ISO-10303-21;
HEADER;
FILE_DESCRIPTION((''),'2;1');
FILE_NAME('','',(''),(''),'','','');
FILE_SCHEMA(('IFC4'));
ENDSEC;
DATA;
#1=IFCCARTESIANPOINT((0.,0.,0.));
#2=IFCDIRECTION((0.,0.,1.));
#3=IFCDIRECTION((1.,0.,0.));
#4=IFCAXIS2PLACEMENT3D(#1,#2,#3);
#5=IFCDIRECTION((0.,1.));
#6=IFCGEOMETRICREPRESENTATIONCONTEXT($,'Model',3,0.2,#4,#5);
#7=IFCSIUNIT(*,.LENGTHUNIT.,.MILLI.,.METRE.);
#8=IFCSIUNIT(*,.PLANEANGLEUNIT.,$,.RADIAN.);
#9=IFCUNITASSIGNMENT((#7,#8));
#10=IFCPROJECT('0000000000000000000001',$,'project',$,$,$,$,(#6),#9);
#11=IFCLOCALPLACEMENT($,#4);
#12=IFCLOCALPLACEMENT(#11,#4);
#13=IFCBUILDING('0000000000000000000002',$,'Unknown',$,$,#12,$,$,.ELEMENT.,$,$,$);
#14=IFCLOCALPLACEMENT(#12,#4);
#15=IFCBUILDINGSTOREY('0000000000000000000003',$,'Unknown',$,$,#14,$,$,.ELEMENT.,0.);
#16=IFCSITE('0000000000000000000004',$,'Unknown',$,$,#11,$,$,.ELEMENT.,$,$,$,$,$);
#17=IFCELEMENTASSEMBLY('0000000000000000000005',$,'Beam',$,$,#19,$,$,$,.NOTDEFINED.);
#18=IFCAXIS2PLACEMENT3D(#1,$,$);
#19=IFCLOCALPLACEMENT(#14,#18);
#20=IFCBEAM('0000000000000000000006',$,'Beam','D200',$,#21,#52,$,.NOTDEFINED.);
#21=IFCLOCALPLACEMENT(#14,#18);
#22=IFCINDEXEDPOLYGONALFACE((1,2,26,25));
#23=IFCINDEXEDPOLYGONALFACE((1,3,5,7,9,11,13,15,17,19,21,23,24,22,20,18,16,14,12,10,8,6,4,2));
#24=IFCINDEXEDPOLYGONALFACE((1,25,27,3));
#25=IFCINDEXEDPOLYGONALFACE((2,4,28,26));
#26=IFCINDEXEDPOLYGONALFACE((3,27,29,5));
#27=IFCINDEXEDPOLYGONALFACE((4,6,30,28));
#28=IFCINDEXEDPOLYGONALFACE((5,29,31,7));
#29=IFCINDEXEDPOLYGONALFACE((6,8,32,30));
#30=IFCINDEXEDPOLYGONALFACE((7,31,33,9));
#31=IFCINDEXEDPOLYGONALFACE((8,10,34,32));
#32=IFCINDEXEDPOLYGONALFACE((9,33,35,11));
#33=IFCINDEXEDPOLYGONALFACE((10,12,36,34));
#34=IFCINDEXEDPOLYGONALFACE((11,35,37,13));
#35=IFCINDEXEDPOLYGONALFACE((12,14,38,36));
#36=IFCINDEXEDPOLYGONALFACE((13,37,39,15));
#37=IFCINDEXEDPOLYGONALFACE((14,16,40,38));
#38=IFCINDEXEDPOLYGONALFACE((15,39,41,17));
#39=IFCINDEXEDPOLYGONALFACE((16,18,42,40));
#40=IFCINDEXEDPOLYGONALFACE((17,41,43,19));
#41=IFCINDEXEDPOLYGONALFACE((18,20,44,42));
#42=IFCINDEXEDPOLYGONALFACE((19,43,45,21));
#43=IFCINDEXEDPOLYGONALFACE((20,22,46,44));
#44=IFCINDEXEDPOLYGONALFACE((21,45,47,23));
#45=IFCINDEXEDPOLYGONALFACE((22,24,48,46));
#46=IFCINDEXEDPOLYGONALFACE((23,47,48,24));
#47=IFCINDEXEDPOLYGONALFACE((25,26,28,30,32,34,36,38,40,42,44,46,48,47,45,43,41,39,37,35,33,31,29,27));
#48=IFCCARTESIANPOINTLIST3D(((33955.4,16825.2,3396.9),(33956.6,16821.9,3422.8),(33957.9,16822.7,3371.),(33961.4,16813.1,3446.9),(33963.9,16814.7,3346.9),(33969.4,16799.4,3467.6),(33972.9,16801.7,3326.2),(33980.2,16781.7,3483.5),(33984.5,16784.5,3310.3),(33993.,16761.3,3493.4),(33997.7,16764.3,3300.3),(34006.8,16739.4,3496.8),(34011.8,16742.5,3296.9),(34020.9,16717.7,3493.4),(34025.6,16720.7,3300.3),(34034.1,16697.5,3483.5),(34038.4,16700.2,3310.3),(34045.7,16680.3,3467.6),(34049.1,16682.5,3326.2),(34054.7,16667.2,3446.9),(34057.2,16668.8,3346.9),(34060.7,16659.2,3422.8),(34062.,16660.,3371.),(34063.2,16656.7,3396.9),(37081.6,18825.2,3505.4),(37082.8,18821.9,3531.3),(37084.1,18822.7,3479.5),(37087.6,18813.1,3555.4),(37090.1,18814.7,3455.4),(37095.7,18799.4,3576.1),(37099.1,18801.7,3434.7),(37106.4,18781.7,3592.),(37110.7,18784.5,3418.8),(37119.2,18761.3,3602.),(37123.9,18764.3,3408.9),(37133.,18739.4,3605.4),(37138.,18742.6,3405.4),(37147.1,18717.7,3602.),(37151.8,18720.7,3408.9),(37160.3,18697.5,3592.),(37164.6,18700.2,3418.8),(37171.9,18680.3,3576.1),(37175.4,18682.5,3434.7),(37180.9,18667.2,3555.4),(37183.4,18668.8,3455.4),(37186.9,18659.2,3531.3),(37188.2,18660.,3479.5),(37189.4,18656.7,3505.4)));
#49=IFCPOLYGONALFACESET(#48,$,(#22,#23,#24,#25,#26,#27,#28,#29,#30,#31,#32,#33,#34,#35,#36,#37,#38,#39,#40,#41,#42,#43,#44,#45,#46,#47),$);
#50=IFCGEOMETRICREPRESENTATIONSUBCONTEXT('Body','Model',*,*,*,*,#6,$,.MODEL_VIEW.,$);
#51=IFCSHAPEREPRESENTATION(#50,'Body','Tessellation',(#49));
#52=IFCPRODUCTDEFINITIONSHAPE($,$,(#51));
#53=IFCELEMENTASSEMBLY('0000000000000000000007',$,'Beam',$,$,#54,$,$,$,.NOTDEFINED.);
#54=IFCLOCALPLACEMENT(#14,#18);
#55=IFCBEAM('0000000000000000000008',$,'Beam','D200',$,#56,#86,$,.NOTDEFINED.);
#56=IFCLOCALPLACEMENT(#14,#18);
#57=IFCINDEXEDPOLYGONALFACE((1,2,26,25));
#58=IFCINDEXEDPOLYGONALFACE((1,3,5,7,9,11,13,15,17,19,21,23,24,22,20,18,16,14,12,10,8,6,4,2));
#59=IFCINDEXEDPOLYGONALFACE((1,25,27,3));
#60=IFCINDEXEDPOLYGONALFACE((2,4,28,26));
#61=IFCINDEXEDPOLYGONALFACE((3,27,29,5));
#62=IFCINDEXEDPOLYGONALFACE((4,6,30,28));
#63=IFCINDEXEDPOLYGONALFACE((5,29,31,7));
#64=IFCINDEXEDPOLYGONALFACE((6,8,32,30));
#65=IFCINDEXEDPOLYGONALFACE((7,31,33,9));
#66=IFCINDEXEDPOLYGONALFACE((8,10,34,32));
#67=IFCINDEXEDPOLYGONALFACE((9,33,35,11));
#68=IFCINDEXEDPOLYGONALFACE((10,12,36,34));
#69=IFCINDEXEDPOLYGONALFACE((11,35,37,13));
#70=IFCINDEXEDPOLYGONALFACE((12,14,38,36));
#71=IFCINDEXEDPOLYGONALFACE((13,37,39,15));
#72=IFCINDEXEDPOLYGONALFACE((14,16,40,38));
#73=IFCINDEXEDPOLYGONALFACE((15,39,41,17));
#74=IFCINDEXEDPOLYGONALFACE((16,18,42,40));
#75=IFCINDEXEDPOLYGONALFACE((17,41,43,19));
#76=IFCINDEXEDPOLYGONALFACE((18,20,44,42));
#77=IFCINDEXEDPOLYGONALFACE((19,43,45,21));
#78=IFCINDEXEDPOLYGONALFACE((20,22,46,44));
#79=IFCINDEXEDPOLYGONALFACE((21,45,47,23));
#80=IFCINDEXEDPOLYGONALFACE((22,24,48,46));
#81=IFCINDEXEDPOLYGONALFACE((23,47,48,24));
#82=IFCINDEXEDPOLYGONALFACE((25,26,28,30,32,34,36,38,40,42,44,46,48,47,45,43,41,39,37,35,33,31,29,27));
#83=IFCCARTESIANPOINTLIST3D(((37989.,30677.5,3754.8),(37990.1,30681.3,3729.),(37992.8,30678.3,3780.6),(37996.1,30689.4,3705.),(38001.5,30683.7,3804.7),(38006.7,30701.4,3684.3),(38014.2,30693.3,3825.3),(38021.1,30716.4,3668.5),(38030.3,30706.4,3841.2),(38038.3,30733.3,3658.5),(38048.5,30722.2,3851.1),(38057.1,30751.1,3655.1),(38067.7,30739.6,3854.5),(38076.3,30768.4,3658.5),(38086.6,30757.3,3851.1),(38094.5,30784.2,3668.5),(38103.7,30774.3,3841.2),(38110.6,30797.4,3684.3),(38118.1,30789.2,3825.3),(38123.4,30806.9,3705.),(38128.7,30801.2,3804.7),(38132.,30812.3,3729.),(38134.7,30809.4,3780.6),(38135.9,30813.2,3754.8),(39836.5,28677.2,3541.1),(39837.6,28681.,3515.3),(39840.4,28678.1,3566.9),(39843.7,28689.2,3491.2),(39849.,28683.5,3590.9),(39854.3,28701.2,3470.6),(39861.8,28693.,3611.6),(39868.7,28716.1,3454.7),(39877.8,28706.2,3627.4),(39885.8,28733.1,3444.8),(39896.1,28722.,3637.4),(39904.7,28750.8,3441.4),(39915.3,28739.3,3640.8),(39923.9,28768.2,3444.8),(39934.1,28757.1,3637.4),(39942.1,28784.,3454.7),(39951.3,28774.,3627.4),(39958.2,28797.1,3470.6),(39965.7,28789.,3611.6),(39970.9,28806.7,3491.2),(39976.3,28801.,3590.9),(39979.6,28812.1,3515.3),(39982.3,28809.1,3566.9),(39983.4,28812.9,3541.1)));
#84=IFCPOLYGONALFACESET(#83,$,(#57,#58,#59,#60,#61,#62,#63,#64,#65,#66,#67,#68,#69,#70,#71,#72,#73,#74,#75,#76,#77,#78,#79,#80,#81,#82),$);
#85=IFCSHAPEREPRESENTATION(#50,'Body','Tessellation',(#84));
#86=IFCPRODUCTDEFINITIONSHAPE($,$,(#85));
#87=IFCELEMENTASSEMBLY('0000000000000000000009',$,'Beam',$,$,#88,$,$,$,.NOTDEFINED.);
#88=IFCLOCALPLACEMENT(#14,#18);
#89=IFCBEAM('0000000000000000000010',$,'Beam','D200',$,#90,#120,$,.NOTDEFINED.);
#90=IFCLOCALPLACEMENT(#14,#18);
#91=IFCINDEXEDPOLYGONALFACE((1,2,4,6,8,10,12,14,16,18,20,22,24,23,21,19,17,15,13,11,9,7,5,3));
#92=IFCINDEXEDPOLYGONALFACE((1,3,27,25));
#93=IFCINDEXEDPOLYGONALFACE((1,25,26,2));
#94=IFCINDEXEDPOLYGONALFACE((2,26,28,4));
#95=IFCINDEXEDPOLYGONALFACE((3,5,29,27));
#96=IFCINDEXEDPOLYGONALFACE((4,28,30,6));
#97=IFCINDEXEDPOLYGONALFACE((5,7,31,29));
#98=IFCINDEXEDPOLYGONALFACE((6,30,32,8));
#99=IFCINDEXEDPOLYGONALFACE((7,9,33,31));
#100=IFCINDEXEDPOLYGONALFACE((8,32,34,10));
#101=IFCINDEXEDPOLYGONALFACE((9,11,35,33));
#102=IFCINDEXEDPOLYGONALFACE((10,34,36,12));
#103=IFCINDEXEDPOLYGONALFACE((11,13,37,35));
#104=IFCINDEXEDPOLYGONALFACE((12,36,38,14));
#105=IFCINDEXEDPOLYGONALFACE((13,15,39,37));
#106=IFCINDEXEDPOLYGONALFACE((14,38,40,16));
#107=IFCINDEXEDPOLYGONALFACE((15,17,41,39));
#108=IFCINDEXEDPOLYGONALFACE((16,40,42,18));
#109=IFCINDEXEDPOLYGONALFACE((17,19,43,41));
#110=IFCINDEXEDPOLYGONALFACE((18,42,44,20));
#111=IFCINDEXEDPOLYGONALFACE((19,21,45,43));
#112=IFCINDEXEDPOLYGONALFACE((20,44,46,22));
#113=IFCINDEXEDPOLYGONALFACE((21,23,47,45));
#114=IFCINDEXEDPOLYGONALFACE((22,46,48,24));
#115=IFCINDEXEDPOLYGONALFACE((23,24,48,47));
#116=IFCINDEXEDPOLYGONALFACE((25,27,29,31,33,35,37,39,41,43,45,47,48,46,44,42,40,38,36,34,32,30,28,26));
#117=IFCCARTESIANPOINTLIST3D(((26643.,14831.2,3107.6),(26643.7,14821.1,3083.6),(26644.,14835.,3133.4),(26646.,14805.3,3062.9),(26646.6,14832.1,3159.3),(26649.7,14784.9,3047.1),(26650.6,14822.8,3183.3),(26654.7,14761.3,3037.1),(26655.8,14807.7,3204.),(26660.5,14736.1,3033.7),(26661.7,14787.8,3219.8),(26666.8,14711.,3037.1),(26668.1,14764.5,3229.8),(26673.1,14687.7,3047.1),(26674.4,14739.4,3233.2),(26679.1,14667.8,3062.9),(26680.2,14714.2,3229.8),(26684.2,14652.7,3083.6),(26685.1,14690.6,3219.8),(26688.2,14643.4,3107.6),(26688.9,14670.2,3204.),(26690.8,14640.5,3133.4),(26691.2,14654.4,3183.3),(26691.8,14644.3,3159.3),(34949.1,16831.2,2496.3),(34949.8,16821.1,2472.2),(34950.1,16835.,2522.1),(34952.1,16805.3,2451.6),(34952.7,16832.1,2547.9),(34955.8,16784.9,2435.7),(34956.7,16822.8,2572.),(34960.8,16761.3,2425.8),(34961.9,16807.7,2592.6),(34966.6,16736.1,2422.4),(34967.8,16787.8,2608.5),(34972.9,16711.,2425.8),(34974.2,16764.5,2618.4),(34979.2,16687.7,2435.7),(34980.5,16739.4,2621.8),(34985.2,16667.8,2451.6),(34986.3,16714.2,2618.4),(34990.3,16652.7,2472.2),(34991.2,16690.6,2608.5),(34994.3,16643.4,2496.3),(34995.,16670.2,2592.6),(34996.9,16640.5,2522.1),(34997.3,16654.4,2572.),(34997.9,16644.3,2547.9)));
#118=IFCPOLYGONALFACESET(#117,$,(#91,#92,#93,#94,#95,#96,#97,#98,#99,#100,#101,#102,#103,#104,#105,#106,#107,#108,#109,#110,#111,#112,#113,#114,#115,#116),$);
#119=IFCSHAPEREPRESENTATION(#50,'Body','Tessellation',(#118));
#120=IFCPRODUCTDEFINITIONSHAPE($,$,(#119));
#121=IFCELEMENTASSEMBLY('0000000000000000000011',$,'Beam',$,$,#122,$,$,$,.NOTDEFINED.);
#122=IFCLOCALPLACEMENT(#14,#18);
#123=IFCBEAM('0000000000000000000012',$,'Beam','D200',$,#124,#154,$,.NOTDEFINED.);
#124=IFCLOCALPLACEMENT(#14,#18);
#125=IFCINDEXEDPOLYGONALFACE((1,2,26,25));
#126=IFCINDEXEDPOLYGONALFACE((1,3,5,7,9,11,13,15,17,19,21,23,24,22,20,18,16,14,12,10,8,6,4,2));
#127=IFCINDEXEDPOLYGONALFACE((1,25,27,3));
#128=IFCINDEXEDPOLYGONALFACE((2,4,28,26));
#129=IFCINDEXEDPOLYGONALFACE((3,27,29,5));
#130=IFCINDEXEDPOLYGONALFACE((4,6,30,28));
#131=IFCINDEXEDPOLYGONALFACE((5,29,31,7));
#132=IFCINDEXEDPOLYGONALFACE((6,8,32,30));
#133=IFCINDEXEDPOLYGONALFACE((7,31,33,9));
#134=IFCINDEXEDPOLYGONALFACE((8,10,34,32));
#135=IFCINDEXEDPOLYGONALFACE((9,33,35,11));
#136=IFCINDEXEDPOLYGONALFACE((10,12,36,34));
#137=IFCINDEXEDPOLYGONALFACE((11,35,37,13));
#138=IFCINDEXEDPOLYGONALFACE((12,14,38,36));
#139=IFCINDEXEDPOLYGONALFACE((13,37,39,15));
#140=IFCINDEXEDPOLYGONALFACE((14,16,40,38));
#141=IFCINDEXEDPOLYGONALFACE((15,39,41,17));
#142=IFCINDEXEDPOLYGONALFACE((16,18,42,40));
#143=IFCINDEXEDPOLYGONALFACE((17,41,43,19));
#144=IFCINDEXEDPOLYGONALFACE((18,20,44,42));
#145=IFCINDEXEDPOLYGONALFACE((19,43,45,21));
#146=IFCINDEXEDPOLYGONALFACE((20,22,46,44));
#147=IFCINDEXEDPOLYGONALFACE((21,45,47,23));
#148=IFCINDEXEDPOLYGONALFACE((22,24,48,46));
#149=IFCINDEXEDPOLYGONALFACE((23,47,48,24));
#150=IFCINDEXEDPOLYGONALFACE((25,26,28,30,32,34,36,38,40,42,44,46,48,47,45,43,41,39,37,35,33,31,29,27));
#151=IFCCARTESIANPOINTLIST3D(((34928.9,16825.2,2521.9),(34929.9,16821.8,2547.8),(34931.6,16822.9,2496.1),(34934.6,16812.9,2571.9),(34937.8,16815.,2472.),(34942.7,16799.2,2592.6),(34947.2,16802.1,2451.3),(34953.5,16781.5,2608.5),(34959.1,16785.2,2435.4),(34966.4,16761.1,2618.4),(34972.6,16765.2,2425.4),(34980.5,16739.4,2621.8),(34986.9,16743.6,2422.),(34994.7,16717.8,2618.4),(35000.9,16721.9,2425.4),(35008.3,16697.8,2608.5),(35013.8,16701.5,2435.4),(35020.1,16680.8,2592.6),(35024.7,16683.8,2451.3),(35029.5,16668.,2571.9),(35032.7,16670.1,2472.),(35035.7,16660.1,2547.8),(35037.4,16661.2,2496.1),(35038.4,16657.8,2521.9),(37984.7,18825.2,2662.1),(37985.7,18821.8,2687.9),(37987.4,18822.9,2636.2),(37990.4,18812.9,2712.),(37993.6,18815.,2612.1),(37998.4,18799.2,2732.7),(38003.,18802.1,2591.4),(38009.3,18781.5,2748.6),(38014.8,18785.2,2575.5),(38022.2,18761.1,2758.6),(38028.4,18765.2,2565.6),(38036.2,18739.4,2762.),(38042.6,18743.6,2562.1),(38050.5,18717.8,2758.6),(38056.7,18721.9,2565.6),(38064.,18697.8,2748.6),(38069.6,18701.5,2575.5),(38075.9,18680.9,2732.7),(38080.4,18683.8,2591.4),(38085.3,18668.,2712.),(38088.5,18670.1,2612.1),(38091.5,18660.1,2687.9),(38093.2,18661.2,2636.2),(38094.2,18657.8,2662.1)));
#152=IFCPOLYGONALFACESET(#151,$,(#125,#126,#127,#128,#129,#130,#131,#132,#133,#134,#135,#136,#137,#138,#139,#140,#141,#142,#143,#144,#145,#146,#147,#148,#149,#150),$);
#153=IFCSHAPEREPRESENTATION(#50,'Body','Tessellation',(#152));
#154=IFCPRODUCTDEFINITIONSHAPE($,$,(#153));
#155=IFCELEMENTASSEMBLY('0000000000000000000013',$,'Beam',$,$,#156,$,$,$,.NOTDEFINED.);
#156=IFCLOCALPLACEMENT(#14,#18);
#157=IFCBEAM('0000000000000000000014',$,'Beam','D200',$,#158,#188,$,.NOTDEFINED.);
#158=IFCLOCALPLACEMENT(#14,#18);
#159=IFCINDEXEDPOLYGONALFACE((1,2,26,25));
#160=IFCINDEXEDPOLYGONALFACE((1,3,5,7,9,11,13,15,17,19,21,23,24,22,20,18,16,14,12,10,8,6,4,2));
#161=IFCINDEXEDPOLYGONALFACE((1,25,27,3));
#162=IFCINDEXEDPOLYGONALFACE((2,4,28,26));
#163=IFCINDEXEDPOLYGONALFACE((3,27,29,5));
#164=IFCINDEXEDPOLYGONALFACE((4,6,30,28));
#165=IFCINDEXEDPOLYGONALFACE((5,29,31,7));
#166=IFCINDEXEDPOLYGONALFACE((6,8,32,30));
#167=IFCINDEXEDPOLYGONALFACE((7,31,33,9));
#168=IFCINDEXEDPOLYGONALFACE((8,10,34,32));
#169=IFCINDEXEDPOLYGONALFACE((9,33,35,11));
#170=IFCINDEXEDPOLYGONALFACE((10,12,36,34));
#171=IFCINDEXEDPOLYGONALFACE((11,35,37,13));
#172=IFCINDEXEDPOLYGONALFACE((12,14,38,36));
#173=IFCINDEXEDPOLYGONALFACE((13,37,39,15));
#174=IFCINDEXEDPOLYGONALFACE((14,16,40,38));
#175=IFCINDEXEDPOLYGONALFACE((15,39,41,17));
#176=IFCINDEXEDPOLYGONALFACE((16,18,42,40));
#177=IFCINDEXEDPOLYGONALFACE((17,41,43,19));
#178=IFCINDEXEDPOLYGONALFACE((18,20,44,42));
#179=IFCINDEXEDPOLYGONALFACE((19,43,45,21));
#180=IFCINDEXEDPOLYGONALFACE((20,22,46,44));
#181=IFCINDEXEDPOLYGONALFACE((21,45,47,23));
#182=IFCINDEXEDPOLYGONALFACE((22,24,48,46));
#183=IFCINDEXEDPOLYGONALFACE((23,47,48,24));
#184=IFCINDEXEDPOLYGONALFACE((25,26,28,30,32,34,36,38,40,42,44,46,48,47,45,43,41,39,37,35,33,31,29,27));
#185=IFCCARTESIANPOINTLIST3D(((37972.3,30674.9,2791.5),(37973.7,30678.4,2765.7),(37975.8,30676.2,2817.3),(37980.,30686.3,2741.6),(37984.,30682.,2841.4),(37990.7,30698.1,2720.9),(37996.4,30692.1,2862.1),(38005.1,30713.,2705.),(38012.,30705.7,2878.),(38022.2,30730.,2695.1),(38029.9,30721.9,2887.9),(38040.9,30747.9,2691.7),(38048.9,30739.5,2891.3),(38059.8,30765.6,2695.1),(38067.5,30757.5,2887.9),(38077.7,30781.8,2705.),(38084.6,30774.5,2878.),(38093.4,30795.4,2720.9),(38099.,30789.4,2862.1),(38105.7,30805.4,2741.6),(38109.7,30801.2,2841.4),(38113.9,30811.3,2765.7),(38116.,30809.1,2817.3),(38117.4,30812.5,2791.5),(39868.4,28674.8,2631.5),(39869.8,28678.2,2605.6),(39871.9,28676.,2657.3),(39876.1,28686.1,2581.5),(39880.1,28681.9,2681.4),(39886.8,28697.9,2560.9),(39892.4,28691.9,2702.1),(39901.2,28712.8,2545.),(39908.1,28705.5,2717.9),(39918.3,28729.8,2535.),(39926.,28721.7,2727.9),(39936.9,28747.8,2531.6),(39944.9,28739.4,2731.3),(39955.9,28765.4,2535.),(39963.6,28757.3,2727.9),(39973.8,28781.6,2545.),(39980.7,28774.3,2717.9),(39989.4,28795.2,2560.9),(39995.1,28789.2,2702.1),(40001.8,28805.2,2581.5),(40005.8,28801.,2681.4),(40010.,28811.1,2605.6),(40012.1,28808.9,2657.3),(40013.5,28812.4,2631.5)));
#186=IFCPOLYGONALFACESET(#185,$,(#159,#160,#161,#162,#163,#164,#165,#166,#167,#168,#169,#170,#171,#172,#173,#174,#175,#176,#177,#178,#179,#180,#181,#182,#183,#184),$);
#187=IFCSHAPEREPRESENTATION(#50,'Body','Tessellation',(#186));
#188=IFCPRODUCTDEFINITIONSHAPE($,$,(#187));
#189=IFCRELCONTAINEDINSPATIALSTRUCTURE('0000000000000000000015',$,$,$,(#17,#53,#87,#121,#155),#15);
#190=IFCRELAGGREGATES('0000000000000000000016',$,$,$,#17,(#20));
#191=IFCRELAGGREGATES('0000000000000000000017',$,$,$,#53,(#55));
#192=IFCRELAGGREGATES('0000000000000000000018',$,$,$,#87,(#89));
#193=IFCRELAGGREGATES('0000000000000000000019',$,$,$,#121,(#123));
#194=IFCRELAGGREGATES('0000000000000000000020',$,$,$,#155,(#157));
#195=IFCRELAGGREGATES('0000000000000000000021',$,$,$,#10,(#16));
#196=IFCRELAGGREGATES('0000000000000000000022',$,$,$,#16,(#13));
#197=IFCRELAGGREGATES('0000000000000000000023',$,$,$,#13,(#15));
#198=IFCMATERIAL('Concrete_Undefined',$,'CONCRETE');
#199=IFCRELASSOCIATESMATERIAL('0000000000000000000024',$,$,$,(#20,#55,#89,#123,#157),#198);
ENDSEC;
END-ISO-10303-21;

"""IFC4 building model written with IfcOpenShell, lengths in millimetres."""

from ifc_helpers import new_model, si_unit, direction, frame, origin_with_axes, place, context, subcontext, project, spatial, line, indexed_curve, outline, extrude, material, element, aggregate, save


model = new_model("IFC4")

# Units and contexts
model_context = context("Model", 3, precision=0.2, world=origin_with_axes(), true_north=direction((0.0, 1.0)))
body_context = subcontext(model_context, "Body", "Model", "MODEL_VIEW")
ifc_project = project(units=[si_unit("LENGTHUNIT", "METRE", prefix="MILLI"), si_unit("PLANEANGLEUNIT", "RADIAN")], contexts=[model_context])

# Site, building, storey
site_placement = place(None, origin_with_axes())
site = spatial("IfcSite", under=ifc_project, at=site_placement, Name="Unknown", CompositionType="ELEMENT")
building_placement = place(site_placement, origin_with_axes())
building = spatial("IfcBuilding", under=site, at=building_placement, Name="Unknown", CompositionType="ELEMENT")
storey_placement = place(building_placement, origin_with_axes())
storey = spatial("IfcBuildingStorey", under=building, at=storey_placement, Name="Unknown", CompositionType="ELEMENT", Elevation=0.0)

# Element assemblies, beams
ifc_material = material(Name="Concrete_Undefined", Category="CONCRETE")
assembly_1_placement = place(storey_placement, frame((37135.5, 18741.0, 3505.4), z_axis=(-0.538906, 0.842366, 0.0), x_axis=(-0.842006, -0.538676, -0.029227)))
assembly_1 = element("IfcElementAssembly", 1, at=assembly_1_placement, inside=storey, Name="Beam", PredefinedType="NOTDEFINED")
beam_1_placement = place(assembly_1_placement, origin_with_axes())
beam_1 = element("IfcBeam", 2, at=beam_1_placement, material=ifc_material, Name="Beam", Description="D200", PredefinedType="NOTDEFINED", context=body_context, shape_type="SolidModel", body=[
    extrude(outline(indexed_curve([(100.0, 0.0), (96.6, 25.9), (86.6, 50.0), (70.7, 70.7), (50.0, 86.6), (25.9, 96.6), (0.0, 100.0), (-25.9, 96.6), (-50.0, 86.6), (-70.7, 70.7), (-86.6, 50.0), (-96.6, 25.9), (-100.0, 0.0), (-96.6, -25.9), (-86.6, -50.0), (-70.7, -70.7), (-50.0, -86.6), (-25.9, -96.6), (0.0, -100.0), (25.9, -96.6), (50.0, -86.6), (70.7, -70.7), (86.6, -50.0), (96.6, -25.9)], segments=[line(1, 2, 3, 4, 5, 6, 7, 8, 9, 10, 11, 12, 13, 14, 15, 16, 17, 18, 19, 20, 21, 22, 23, 24, 1)])), frame((0.0, 0.0, 0.0), z_axis=(-1.0, 0.0, 0.0), x_axis=(0.0, 0.0, 1.0)), (0.0, 0.0, -1.0), 3712.8),
])
aggregate(assembly_1, [beam_1])
assembly_2_placement = place(storey_placement, frame((38062.4, 30745.3, 3754.8), z_axis=(-0.734583, -0.678519, 0.0), x_axis=(0.676438, -0.732329, -0.078267)))
assembly_2 = element("IfcElementAssembly", 3, at=assembly_2_placement, inside=storey, Name="Beam", PredefinedType="NOTDEFINED")
beam_2_placement = place(assembly_2_placement, origin_with_axes())
beam_2 = element("IfcBeam", 4, at=beam_2_placement, material=ifc_material, Name="Beam", Description="D200", PredefinedType="NOTDEFINED", context=body_context, shape_type="SolidModel", body=[
    extrude(outline(indexed_curve([(100.0, 0.0), (96.6, 25.9), (86.6, 50.0), (70.7, 70.7), (50.0, 86.6), (25.9, 96.6), (0.0, 100.0), (-25.9, 96.6), (-50.0, 86.6), (-70.7, 70.7), (-86.6, 50.0), (-96.6, 25.9), (-100.0, 0.0), (-96.6, -25.9), (-86.6, -50.0), (-70.7, -70.7), (-50.0, -86.6), (-25.9, -96.6), (0.0, -100.0), (25.9, -96.6), (50.0, -86.6), (70.7, -70.7), (86.6, -50.0), (96.6, -25.9)], segments=[line(1, 2, 3, 4, 5, 6, 7, 8, 9, 10, 11, 12, 13, 14, 15, 16, 17, 18, 19, 20, 21, 22, 23, 24, 1)])), frame((0.0, 0.0, 0.0), z_axis=(-1.0, 0.0, 0.0), x_axis=(0.0, 0.0, 1.0)), (0.0, 0.0, -1.0), 2731.3),
])
aggregate(assembly_2, [beam_2])
assembly_3_placement = place(storey_placement, frame((34973.5, 16737.7, 2522.1), z_axis=(-0.234096, 0.972213, 0.0), x_axis=(-0.969734, -0.233499, 0.071373)))
assembly_3 = element("IfcElementAssembly", 5, at=assembly_3_placement, inside=storey, Name="Beam", PredefinedType="NOTDEFINED")
beam_3_placement = place(assembly_3_placement, origin_with_axes())
beam_3 = element("IfcBeam", 6, at=beam_3_placement, material=ifc_material, Name="Beam", Description="D200", PredefinedType="NOTDEFINED", context=body_context, shape_type="SolidModel", body=[
    extrude(outline(indexed_curve([(100.0, 0.0), (96.6, 25.9), (86.6, 50.0), (70.7, 70.7), (50.0, 86.6), (25.9, 96.6), (0.0, 100.0), (-25.9, 96.6), (-50.0, 86.6), (-70.7, 70.7), (-86.6, 50.0), (-96.6, 25.9), (-100.0, 0.0), (-96.6, -25.9), (-86.6, -50.0), (-70.7, -70.7), (-50.0, -86.6), (-25.9, -96.6), (0.0, -100.0), (25.9, -96.6), (50.0, -86.6), (70.7, -70.7), (86.6, -50.0), (96.6, -25.9)], segments=[line(1, 2, 3, 4, 5, 6, 7, 8, 9, 10, 11, 12, 13, 14, 15, 16, 17, 18, 19, 20, 21, 22, 23, 24, 1)])), frame((0.0, 0.0, 0.0), z_axis=(-1.0, 0.0, 0.0), x_axis=(0.0, 0.0, 1.0)), (0.0, 0.0, -1.0), 8565.3),
])
aggregate(assembly_3, [beam_3])
assembly_4_placement = place(storey_placement, frame((38039.4, 18741.5, 2662.1), z_axis=(-0.547633, 0.836719, 0.0), x_axis=(-0.836103, -0.54723, -0.038349)))
assembly_4 = element("IfcElementAssembly", 7, at=assembly_4_placement, inside=storey, Name="Beam", PredefinedType="NOTDEFINED")
beam_4_placement = place(assembly_4_placement, origin_with_axes())
beam_4 = element("IfcBeam", 8, at=beam_4_placement, material=ifc_material, Name="Beam", Description="D200", PredefinedType="NOTDEFINED", context=body_context, shape_type="SolidModel", body=[
    extrude(outline(indexed_curve([(100.0, 0.0), (96.6, 25.9), (86.6, 50.0), (70.7, 70.7), (50.0, 86.6), (25.9, 96.6), (0.0, 100.0), (-25.9, 96.6), (-50.0, 86.6), (-70.7, 70.7), (-86.6, 50.0), (-96.6, 25.9), (-100.0, 0.0), (-96.6, -25.9), (-86.6, -50.0), (-70.7, -70.7), (-50.0, -86.6), (-25.9, -96.6), (0.0, -100.0), (25.9, -96.6), (50.0, -86.6), (70.7, -70.7), (86.6, -50.0), (96.6, -25.9)], segments=[line(1, 2, 3, 4, 5, 6, 7, 8, 9, 10, 11, 12, 13, 14, 15, 16, 17, 18, 19, 20, 21, 22, 23, 24, 1)])), frame((0.0, 0.0, 0.0), z_axis=(-1.0, 0.0, 0.0), x_axis=(0.0, 0.0, 1.0)), (0.0, 0.0, -1.0), 3654.8),
])
aggregate(assembly_4, [beam_4])
assembly_5_placement = place(storey_placement, frame((38044.9, 30743.7, 2791.5), z_axis=(-0.725743, -0.687966, 0.0), x_axis=(0.686809, -0.724522, -0.057971)))
assembly_5 = element("IfcElementAssembly", 9, at=assembly_5_placement, inside=storey, Name="Beam", PredefinedType="NOTDEFINED")
beam_5_placement = place(assembly_5_placement, origin_with_axes())
beam_5 = element("IfcBeam", 10, at=beam_5_placement, material=ifc_material, Name="Beam", Description="D200", PredefinedType="NOTDEFINED", context=body_context, shape_type="SolidModel", body=[
    extrude(outline(indexed_curve([(100.0, 0.0), (96.6, 25.9), (86.6, 50.0), (70.7, 70.7), (50.0, 86.6), (25.9, 96.6), (0.0, 100.0), (-25.9, 96.6), (-50.0, 86.6), (-70.7, 70.7), (-86.6, 50.0), (-96.6, 25.9), (-100.0, 0.0), (-96.6, -25.9), (-86.6, -50.0), (-70.7, -70.7), (-50.0, -86.6), (-25.9, -96.6), (0.0, -100.0), (25.9, -96.6), (50.0, -86.6), (70.7, -70.7), (86.6, -50.0), (96.6, -25.9)], segments=[line(1, 2, 3, 4, 5, 6, 7, 8, 9, 10, 11, 12, 13, 14, 15, 16, 17, 18, 19, 20, 21, 22, 23, 24, 1)])), frame((0.0, 0.0, 0.0), z_axis=(-1.0, 0.0, 0.0), x_axis=(0.0, 0.0, 1.0)), (0.0, 0.0, -1.0), 2760.7),
])
aggregate(assembly_5, [beam_5])

save(model, "model.ifc")
